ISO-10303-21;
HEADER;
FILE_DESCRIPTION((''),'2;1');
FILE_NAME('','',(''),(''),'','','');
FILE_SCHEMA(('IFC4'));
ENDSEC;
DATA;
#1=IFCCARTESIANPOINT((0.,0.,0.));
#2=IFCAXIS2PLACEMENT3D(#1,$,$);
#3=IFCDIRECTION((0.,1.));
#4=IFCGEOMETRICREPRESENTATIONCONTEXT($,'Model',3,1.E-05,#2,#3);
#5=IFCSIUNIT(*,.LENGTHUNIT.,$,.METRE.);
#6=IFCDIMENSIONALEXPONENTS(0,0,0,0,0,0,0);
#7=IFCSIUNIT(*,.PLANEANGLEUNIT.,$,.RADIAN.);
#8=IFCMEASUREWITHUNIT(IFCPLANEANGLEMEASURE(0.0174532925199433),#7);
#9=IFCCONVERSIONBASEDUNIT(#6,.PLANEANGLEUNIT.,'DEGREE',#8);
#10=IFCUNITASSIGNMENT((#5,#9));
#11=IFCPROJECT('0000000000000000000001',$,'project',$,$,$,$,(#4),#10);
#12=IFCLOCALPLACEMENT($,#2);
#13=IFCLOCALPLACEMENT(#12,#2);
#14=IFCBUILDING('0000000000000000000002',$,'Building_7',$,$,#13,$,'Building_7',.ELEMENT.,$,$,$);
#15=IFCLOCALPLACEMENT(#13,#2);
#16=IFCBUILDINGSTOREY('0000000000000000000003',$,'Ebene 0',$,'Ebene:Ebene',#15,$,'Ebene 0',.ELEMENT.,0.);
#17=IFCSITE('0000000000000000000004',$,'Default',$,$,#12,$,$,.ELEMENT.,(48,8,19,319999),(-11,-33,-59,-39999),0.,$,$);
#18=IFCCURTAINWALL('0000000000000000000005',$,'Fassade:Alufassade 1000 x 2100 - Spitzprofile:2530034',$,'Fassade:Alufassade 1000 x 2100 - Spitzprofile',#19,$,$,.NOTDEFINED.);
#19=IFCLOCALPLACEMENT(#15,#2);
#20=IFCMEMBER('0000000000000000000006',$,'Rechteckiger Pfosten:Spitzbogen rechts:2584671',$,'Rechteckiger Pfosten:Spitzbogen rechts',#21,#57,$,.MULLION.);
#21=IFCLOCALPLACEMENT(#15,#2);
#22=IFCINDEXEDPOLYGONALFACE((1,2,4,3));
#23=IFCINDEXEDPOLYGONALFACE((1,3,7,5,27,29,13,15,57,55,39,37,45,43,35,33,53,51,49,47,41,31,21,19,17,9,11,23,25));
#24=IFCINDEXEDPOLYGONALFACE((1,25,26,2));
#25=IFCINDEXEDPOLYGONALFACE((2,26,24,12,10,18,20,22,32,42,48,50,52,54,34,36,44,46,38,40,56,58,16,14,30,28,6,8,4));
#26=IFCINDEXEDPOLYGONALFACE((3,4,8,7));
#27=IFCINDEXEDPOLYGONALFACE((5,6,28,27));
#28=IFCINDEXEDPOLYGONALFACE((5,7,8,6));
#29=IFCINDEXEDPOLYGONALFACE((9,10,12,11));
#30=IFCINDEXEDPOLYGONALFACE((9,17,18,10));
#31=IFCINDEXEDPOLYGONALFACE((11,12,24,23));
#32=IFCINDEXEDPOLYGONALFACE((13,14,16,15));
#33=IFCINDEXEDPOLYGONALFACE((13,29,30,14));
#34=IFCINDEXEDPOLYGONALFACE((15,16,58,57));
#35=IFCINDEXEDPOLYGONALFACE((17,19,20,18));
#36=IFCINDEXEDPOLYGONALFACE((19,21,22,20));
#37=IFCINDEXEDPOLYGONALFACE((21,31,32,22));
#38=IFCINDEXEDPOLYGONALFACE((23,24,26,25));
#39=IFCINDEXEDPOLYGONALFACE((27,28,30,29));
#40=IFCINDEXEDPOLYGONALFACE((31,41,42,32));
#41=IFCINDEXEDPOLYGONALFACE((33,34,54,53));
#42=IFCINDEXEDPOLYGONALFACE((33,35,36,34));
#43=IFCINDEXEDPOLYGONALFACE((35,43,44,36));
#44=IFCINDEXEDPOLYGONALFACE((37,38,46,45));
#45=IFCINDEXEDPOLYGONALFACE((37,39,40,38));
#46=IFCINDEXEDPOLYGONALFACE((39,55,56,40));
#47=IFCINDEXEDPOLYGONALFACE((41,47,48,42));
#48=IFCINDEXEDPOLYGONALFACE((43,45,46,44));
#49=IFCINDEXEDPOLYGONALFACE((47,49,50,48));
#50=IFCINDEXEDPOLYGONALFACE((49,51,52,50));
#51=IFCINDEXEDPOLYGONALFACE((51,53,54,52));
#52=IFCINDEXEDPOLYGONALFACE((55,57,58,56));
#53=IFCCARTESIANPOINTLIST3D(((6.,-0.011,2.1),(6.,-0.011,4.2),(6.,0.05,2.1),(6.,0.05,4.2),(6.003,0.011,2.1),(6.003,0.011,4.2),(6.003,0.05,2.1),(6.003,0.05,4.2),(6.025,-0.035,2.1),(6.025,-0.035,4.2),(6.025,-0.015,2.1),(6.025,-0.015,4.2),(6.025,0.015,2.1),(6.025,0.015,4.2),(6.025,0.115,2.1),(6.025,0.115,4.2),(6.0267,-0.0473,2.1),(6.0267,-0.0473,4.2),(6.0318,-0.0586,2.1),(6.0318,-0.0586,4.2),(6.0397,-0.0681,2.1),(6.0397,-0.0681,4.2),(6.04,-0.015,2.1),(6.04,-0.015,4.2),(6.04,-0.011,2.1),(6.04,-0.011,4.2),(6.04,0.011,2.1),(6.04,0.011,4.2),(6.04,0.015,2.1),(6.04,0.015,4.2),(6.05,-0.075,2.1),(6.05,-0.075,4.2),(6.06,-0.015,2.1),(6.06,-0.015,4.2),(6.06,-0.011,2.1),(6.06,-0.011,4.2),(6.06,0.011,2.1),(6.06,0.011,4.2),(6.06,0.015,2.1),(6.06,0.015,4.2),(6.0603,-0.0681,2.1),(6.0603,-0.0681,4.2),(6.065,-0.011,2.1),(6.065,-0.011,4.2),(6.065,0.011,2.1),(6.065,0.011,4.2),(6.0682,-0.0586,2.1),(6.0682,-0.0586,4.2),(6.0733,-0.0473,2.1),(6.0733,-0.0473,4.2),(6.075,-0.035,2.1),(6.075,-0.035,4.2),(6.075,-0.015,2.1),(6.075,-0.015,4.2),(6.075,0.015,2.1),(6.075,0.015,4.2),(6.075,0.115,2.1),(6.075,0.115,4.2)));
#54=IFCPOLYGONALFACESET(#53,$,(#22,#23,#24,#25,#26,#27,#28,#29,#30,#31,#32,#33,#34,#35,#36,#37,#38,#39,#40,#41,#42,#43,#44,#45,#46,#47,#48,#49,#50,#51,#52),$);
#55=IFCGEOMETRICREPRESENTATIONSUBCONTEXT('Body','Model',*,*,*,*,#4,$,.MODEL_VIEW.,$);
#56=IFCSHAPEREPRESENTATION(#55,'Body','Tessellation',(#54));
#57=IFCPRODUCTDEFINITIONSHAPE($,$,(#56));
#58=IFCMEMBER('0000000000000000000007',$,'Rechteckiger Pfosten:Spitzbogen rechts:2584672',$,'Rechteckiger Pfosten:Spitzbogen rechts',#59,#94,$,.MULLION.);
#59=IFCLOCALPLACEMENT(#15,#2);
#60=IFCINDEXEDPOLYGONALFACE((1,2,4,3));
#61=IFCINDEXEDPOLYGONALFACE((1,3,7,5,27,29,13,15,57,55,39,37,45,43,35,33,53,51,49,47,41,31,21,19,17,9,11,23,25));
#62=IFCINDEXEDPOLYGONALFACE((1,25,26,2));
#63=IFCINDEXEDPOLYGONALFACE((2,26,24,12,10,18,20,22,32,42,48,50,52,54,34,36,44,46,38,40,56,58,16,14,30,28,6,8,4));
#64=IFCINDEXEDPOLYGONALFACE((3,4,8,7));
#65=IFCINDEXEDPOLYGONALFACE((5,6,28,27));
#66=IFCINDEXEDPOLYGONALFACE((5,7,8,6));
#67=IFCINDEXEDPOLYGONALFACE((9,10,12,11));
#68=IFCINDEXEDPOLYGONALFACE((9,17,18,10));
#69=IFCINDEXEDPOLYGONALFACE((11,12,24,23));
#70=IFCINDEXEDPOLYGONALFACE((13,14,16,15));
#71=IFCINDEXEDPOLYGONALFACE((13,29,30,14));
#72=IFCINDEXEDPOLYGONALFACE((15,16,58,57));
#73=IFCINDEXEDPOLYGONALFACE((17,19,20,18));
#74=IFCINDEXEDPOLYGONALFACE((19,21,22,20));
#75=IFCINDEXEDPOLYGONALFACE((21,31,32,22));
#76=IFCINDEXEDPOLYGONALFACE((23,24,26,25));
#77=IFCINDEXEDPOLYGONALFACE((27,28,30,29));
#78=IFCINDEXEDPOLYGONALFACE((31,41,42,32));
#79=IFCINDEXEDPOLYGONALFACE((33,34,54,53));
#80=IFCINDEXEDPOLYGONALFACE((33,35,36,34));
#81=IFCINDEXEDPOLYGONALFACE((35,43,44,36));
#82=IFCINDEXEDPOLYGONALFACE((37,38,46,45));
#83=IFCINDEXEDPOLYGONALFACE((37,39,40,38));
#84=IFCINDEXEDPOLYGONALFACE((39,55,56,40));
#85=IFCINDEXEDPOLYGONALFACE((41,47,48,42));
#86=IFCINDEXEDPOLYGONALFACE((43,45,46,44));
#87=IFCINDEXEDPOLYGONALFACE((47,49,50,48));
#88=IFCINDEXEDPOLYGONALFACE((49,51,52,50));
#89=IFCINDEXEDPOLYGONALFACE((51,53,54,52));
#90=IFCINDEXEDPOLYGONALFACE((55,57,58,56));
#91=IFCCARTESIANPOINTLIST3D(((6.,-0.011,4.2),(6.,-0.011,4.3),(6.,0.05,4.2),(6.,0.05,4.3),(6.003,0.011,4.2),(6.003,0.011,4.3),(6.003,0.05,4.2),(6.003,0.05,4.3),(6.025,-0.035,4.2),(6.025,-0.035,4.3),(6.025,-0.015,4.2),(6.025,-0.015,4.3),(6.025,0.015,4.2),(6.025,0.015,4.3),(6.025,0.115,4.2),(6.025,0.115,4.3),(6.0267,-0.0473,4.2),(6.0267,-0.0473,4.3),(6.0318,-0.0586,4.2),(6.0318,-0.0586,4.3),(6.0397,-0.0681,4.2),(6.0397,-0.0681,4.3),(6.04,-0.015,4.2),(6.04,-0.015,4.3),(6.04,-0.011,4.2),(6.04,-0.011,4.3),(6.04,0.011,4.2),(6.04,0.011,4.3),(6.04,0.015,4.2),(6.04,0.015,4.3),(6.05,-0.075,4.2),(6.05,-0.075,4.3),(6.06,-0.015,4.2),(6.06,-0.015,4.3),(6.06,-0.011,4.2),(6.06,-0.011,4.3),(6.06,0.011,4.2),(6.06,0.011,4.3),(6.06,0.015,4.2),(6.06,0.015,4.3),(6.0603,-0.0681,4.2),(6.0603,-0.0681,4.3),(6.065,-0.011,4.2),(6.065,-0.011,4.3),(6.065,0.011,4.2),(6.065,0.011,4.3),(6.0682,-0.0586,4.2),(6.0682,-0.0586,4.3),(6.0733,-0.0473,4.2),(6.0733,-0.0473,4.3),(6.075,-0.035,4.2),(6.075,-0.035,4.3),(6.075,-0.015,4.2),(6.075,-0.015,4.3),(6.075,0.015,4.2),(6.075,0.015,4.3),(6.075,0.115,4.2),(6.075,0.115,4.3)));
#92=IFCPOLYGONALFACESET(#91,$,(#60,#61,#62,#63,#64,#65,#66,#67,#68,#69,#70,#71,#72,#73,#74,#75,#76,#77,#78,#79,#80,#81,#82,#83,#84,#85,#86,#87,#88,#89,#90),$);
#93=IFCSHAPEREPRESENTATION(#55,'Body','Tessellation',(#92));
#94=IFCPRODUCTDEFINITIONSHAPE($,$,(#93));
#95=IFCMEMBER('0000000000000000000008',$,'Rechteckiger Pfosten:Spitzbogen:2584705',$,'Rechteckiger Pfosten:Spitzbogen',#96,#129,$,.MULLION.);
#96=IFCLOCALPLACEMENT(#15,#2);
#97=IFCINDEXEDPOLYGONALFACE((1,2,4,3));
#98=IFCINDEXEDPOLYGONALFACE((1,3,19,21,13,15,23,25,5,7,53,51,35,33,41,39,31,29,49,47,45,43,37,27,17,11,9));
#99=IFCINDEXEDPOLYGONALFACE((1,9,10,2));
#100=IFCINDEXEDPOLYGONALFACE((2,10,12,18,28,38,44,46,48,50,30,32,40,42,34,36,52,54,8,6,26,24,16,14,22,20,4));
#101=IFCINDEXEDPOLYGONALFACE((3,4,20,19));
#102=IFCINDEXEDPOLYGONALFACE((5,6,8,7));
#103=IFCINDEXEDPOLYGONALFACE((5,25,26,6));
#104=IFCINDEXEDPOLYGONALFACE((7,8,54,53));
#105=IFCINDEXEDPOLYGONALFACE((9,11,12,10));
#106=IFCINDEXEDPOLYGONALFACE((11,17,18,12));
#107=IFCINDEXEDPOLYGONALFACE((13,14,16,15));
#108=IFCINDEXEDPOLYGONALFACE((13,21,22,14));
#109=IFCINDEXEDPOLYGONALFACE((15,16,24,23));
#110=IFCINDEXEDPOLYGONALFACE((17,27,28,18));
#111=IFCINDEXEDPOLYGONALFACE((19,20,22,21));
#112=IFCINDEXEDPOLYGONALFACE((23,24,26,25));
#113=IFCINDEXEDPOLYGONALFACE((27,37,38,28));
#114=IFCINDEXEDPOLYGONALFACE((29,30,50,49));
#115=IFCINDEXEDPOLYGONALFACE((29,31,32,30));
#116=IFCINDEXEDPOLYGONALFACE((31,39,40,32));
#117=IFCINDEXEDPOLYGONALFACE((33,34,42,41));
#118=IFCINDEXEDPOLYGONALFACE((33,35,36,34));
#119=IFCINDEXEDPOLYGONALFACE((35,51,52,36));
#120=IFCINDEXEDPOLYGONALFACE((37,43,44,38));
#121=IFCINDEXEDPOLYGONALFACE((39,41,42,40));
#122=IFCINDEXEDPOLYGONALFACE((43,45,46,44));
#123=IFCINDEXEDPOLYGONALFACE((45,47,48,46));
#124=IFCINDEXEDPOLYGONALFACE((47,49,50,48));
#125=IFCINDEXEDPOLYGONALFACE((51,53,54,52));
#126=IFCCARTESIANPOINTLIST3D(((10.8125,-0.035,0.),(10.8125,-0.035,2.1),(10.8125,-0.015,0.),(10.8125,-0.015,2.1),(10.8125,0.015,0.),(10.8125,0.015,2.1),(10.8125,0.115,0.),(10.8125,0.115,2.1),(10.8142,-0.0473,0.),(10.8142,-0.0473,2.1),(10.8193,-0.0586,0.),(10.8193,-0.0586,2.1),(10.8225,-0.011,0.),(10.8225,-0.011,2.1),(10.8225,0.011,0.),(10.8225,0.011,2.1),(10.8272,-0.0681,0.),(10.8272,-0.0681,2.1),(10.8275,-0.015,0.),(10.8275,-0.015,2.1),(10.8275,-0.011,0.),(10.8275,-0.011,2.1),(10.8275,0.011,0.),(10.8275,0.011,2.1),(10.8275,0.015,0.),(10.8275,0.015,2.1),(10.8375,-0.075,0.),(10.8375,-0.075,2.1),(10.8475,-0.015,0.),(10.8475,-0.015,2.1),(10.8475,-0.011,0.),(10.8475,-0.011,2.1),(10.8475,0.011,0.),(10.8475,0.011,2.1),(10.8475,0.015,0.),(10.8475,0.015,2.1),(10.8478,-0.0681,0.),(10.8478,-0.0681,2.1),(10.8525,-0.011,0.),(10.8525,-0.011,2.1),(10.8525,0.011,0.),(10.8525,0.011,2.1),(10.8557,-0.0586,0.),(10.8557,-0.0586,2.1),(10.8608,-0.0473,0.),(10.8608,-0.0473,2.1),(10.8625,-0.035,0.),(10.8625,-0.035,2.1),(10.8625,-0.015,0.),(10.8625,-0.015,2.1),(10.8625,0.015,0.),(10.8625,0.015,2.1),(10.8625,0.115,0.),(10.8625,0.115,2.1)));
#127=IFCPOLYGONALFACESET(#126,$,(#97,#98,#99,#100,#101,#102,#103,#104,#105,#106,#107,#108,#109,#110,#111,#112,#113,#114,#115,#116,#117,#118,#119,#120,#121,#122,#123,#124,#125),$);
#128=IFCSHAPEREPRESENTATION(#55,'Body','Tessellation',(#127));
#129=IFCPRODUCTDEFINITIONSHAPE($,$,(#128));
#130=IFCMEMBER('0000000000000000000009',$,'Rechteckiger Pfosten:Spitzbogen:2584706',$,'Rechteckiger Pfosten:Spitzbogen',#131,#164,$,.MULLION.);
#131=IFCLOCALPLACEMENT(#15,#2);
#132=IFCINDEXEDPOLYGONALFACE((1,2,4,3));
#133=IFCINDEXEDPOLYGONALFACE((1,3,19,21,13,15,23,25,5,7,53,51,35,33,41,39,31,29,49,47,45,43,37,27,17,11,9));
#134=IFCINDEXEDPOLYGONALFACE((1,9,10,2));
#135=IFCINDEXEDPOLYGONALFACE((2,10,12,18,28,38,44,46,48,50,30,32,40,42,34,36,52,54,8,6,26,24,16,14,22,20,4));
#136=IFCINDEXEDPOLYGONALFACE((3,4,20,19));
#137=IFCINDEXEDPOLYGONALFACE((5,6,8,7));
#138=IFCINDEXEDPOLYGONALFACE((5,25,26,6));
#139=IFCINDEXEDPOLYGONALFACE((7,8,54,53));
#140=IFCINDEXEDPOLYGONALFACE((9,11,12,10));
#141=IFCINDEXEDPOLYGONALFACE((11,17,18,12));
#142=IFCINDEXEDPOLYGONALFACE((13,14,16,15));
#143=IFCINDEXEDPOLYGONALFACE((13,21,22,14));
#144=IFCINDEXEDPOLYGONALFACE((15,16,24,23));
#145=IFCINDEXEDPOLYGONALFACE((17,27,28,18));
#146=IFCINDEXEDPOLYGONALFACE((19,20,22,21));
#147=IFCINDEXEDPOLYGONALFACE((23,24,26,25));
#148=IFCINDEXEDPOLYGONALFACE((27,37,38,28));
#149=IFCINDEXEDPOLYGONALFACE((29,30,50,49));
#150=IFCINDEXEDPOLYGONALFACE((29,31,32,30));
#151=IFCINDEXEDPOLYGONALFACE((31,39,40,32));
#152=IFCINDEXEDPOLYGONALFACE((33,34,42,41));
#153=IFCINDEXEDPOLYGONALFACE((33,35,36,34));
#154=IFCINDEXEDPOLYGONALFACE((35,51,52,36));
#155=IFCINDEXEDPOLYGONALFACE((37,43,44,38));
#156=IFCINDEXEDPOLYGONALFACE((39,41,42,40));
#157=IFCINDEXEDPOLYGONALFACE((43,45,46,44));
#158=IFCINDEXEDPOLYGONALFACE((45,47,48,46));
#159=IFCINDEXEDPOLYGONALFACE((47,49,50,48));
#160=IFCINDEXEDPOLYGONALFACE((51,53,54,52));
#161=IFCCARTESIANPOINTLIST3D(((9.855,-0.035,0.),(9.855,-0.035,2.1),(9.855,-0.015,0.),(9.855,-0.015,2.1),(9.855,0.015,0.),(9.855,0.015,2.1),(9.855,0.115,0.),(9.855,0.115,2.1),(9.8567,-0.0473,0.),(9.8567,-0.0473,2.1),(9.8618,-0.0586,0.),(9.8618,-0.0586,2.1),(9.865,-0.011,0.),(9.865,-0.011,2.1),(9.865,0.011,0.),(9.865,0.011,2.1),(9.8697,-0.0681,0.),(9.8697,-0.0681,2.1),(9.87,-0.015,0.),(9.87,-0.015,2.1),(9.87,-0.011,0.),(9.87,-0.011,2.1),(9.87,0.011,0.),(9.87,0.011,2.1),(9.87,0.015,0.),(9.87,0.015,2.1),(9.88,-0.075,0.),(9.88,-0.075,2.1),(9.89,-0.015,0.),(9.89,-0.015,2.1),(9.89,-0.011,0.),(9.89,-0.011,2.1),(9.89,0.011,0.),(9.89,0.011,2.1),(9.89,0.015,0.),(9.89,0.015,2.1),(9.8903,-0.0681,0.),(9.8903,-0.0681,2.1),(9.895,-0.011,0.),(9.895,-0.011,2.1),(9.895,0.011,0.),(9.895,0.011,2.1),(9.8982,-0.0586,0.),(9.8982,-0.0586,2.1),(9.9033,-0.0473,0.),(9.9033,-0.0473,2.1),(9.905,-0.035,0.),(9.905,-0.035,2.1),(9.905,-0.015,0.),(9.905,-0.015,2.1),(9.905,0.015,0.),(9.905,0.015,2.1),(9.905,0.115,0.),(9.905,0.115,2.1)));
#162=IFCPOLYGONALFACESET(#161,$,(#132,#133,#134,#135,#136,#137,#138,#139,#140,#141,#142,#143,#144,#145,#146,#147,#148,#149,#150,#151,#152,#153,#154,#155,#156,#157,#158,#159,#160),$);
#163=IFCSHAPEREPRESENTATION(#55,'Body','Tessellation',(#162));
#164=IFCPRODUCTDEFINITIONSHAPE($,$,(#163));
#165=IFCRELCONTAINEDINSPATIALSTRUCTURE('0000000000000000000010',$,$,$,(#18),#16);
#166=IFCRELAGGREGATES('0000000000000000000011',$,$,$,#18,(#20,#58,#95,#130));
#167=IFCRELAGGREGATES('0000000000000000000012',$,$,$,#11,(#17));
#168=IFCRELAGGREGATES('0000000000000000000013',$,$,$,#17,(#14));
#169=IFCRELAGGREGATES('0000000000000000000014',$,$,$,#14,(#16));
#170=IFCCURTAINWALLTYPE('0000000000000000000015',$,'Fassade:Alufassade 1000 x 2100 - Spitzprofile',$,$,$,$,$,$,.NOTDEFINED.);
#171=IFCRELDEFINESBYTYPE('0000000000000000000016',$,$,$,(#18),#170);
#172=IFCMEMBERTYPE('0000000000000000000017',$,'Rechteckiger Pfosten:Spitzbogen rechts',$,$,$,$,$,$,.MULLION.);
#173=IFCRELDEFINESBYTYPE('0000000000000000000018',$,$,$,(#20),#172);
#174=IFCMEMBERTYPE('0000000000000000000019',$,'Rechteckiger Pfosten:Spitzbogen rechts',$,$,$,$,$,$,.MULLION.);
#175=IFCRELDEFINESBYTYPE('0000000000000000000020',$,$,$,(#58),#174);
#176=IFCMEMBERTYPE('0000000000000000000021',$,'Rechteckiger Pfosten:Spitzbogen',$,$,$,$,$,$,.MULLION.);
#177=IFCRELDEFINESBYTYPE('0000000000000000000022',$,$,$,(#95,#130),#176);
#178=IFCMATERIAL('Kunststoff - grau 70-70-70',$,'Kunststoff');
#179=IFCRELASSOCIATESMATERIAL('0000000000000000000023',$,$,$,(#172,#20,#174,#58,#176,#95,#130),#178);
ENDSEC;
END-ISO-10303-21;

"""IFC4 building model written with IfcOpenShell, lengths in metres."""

from ifc_helpers import new_model, entity, si_unit, converted_unit, direction, frame, origin, place, context, subcontext, project, spatial, line, arc, indexed_curve, outline, extrude, source, transform, mapped, material, type_object, type_shapes, element, aggregate, save


model = new_model("IFC4")

# Units and contexts
model_context = context("Model", 3, precision=1e-05, world=origin(), true_north=direction((0.0, 1.0)))
body_context = subcontext(model_context, "Body", "Model", "MODEL_VIEW")
ifc_project = project(units=[si_unit("LENGTHUNIT", "METRE"), converted_unit("PLANEANGLEUNIT", "DEGREE", entity("IfcPlaneAngleMeasure", 0.0174532925199433), si_unit("PLANEANGLEUNIT", "RADIAN"), dimensions=[0, 0, 0, 0, 0, 0, 0])], contexts=[model_context])

# Site, building, storey
site_placement = place(None, origin())
site = spatial("IfcSite", under=ifc_project, at=site_placement, Name="Default", CompositionType="ELEMENT", RefLatitude=(48, 8, 19, 319999), RefLongitude=(-11, -33, -59, -39999), RefElevation=0.0)
building_placement = place(site_placement, origin())
building = spatial("IfcBuilding", under=site, at=building_placement, Name="Building_7", LongName="Building_7", CompositionType="ELEMENT")
storey_placement = place(building_placement, origin())
storey = spatial("IfcBuildingStorey", under=building, at=storey_placement, Name="Ebene 0", ObjectType="Ebene:Ebene", LongName="Ebene 0", CompositionType="ELEMENT", Elevation=0.0)

# Curtain wall, members
curtain_wall_type = type_object("IfcCurtainWallType", Name="Fassade:Alufassade 1000 x 2100 - Spitzprofile", PredefinedType="NOTDEFINED")
curtain_wall_placement = place(storey_placement, origin())
curtain_wall = element("IfcCurtainWall", 1, at=curtain_wall_placement, inside=storey, type_object=curtain_wall_type, Name="Fassade:Alufassade 1000 x 2100 - Spitzprofile:2530034", ObjectType="Fassade:Alufassade 1000 x 2100 - Spitzprofile", PredefinedType="NOTDEFINED")
ifc_material = material(Name="Kunststoff - grau 70-70-70", Category="Kunststoff")
member_type_1 = type_object("IfcMemberType", Name="Rechteckiger Pfosten:Spitzbogen rechts", PredefinedType="MULLION", material=ifc_material)
shared_shape_1 = source(origin(), body_context, "Body", "SweptSolid", [
    extrude(outline(indexed_curve([(-0.107, -0.0321), (-0.007, -0.0321), (-0.007, -0.0171), (-0.003, -0.0171), (-0.003, -0.0221), (0.019, -0.0221), (0.019, -0.0171), (0.023, -0.0171), (0.023, -0.0321), (0.043, -0.0321), (0.0666, -0.0254), (0.083, -0.0071), (0.0666, 0.0111), (0.043, 0.0179), (0.023, 0.0179), (0.023, 0.0029), (0.019, 0.0029), (0.019, 0.0429), (-0.042, 0.0429), (-0.042, 0.0399), (-0.003, 0.0399), (-0.003, 0.0029), (-0.007, 0.0029), (-0.007, 0.0179), (-0.107, 0.0179)], segments=[line(1, 2, 3, 4, 5, 6, 7, 8, 9, 10), arc(10, 11, 12), arc(12, 13, 14), line(14, 15, 16, 17, 18, 19, 20, 21, 22, 23, 24, 25, 1)], self_intersect=False)), frame((-0.0429, 0.008, -2.1), z_axis=(0.0, 0.0, 1.0), x_axis=(0.0, -1.0, 0.0)), (0.0, 0.0, 1.0), 2.1),
])
type_shapes(member_type_1, [shared_shape_1])
member_1_placement = place(curtain_wall_placement, frame((6.0, 0.0, 2.1), z_axis=(0.0, 0.0, -1.0), x_axis=(-1.0, 0.0, 0.0)))
member_1 = element("IfcMember", 2, at=member_1_placement, type_object=member_type_1, material=ifc_material, Name="Rechteckiger Pfosten:Spitzbogen rechts:2584671", ObjectType="Rechteckiger Pfosten:Spitzbogen rechts", PredefinedType="MULLION", context=body_context, shape_type="MappedRepresentation", body=[
    mapped(shared_shape_1, transform((0.0, 0.0, 0.0), scale=1.0)),
])
member_type_2 = type_object("IfcMemberType", Name="Rechteckiger Pfosten:Spitzbogen rechts", PredefinedType="MULLION", material=ifc_material)
shared_shape_2 = source(origin(), body_context, "Body", "SweptSolid", [
    extrude(outline(indexed_curve([(-0.107, -0.0321), (-0.007, -0.0321), (-0.007, -0.0171), (-0.003, -0.0171), (-0.003, -0.0221), (0.019, -0.0221), (0.019, -0.0171), (0.023, -0.0171), (0.023, -0.0321), (0.043, -0.0321), (0.0666, -0.0254), (0.083, -0.0071), (0.0666, 0.0111), (0.043, 0.0179), (0.023, 0.0179), (0.023, 0.0029), (0.019, 0.0029), (0.019, 0.0429), (-0.042, 0.0429), (-0.042, 0.0399), (-0.003, 0.0399), (-0.003, 0.0029), (-0.007, 0.0029), (-0.007, 0.0179), (-0.107, 0.0179)], segments=[line(1, 2, 3, 4, 5, 6, 7, 8, 9, 10), arc(10, 11, 12), arc(12, 13, 14), line(14, 15, 16, 17, 18, 19, 20, 21, 22, 23, 24, 25, 1)], self_intersect=False)), frame((-0.0429, 0.008, -0.1), z_axis=(0.0, 0.0, 1.0), x_axis=(0.0, -1.0, 0.0)), (0.0, 0.0, 1.0), 0.1),
])
type_shapes(member_type_2, [shared_shape_2])
member_2_placement = place(curtain_wall_placement, frame((6.0, 0.0, 4.2), z_axis=(0.0, 0.0, -1.0), x_axis=(-1.0, 0.0, 0.0)))
member_2 = element("IfcMember", 3, at=member_2_placement, type_object=member_type_2, material=ifc_material, Name="Rechteckiger Pfosten:Spitzbogen rechts:2584672", ObjectType="Rechteckiger Pfosten:Spitzbogen rechts", PredefinedType="MULLION", context=body_context, shape_type="MappedRepresentation", body=[
    mapped(shared_shape_2, transform((0.0, 0.0, 0.0), scale=1.0)),
])
member_type_3 = type_object("IfcMemberType", Name="Rechteckiger Pfosten:Spitzbogen", PredefinedType="MULLION", material=ifc_material)
shared_shape_3 = source(origin(), body_context, "Body", "SweptSolid", [
    extrude(outline(indexed_curve([(-0.111, -0.025), (-0.011, -0.025), (-0.011, -0.01), (-0.007, -0.01), (-0.007, -0.015), (0.015, -0.015), (0.015, -0.01), (0.019, -0.01), (0.019, -0.025), (0.039, -0.025), (0.0626, -0.0182), (0.079, 0.0), (0.0626, 0.0182), (0.039, 0.025), (0.019, 0.025), (0.019, 0.01), (0.015, 0.01), (0.015, 0.015), (-0.007, 0.015), (-0.007, 0.01), (-0.011, 0.01), (-0.011, 0.025), (-0.111, 0.025)], segments=[line(1, 2, 3, 4, 5, 6, 7, 8, 9, 10), arc(10, 11, 12), arc(12, 13, 14), line(14, 15, 16, 17, 18, 19, 20, 21, 22, 23, 1)], self_intersect=False)), frame((0.0, 0.004, -2.1), z_axis=(0.0, 0.0, 1.0), x_axis=(0.0, -1.0, 0.0)), (0.0, 0.0, 1.0), 2.1),
])
type_shapes(member_type_3, [shared_shape_3])
member_3_placement = place(curtain_wall_placement, frame((10.8375, 0.0, 0.0), z_axis=(0.0, 0.0, -1.0), x_axis=(-1.0, 0.0, 0.0)))
member_3 = element("IfcMember", 4, at=member_3_placement, type_object=member_type_3, material=ifc_material, Name="Rechteckiger Pfosten:Spitzbogen:2584705", ObjectType="Rechteckiger Pfosten:Spitzbogen", PredefinedType="MULLION", context=body_context, shape_type="MappedRepresentation", body=[
    mapped(shared_shape_3, transform((0.0, 0.0, 0.0), scale=1.0)),
])
member_4_placement = place(curtain_wall_placement, frame((9.88, 0.0, 0.0), z_axis=(0.0, 0.0, -1.0), x_axis=(-1.0, 0.0, 0.0)))
member_4 = element("IfcMember", 5, at=member_4_placement, type_object=member_type_3, material=ifc_material, Name="Rechteckiger Pfosten:Spitzbogen:2584706", ObjectType="Rechteckiger Pfosten:Spitzbogen", PredefinedType="MULLION", context=body_context, shape_type="MappedRepresentation", body=[
    mapped(shared_shape_3, transform((0.0, 0.0, 0.0), scale=1.0)),
])
aggregate(curtain_wall, [member_1, member_2, member_3, member_4])

save(model, "model.ifc")
